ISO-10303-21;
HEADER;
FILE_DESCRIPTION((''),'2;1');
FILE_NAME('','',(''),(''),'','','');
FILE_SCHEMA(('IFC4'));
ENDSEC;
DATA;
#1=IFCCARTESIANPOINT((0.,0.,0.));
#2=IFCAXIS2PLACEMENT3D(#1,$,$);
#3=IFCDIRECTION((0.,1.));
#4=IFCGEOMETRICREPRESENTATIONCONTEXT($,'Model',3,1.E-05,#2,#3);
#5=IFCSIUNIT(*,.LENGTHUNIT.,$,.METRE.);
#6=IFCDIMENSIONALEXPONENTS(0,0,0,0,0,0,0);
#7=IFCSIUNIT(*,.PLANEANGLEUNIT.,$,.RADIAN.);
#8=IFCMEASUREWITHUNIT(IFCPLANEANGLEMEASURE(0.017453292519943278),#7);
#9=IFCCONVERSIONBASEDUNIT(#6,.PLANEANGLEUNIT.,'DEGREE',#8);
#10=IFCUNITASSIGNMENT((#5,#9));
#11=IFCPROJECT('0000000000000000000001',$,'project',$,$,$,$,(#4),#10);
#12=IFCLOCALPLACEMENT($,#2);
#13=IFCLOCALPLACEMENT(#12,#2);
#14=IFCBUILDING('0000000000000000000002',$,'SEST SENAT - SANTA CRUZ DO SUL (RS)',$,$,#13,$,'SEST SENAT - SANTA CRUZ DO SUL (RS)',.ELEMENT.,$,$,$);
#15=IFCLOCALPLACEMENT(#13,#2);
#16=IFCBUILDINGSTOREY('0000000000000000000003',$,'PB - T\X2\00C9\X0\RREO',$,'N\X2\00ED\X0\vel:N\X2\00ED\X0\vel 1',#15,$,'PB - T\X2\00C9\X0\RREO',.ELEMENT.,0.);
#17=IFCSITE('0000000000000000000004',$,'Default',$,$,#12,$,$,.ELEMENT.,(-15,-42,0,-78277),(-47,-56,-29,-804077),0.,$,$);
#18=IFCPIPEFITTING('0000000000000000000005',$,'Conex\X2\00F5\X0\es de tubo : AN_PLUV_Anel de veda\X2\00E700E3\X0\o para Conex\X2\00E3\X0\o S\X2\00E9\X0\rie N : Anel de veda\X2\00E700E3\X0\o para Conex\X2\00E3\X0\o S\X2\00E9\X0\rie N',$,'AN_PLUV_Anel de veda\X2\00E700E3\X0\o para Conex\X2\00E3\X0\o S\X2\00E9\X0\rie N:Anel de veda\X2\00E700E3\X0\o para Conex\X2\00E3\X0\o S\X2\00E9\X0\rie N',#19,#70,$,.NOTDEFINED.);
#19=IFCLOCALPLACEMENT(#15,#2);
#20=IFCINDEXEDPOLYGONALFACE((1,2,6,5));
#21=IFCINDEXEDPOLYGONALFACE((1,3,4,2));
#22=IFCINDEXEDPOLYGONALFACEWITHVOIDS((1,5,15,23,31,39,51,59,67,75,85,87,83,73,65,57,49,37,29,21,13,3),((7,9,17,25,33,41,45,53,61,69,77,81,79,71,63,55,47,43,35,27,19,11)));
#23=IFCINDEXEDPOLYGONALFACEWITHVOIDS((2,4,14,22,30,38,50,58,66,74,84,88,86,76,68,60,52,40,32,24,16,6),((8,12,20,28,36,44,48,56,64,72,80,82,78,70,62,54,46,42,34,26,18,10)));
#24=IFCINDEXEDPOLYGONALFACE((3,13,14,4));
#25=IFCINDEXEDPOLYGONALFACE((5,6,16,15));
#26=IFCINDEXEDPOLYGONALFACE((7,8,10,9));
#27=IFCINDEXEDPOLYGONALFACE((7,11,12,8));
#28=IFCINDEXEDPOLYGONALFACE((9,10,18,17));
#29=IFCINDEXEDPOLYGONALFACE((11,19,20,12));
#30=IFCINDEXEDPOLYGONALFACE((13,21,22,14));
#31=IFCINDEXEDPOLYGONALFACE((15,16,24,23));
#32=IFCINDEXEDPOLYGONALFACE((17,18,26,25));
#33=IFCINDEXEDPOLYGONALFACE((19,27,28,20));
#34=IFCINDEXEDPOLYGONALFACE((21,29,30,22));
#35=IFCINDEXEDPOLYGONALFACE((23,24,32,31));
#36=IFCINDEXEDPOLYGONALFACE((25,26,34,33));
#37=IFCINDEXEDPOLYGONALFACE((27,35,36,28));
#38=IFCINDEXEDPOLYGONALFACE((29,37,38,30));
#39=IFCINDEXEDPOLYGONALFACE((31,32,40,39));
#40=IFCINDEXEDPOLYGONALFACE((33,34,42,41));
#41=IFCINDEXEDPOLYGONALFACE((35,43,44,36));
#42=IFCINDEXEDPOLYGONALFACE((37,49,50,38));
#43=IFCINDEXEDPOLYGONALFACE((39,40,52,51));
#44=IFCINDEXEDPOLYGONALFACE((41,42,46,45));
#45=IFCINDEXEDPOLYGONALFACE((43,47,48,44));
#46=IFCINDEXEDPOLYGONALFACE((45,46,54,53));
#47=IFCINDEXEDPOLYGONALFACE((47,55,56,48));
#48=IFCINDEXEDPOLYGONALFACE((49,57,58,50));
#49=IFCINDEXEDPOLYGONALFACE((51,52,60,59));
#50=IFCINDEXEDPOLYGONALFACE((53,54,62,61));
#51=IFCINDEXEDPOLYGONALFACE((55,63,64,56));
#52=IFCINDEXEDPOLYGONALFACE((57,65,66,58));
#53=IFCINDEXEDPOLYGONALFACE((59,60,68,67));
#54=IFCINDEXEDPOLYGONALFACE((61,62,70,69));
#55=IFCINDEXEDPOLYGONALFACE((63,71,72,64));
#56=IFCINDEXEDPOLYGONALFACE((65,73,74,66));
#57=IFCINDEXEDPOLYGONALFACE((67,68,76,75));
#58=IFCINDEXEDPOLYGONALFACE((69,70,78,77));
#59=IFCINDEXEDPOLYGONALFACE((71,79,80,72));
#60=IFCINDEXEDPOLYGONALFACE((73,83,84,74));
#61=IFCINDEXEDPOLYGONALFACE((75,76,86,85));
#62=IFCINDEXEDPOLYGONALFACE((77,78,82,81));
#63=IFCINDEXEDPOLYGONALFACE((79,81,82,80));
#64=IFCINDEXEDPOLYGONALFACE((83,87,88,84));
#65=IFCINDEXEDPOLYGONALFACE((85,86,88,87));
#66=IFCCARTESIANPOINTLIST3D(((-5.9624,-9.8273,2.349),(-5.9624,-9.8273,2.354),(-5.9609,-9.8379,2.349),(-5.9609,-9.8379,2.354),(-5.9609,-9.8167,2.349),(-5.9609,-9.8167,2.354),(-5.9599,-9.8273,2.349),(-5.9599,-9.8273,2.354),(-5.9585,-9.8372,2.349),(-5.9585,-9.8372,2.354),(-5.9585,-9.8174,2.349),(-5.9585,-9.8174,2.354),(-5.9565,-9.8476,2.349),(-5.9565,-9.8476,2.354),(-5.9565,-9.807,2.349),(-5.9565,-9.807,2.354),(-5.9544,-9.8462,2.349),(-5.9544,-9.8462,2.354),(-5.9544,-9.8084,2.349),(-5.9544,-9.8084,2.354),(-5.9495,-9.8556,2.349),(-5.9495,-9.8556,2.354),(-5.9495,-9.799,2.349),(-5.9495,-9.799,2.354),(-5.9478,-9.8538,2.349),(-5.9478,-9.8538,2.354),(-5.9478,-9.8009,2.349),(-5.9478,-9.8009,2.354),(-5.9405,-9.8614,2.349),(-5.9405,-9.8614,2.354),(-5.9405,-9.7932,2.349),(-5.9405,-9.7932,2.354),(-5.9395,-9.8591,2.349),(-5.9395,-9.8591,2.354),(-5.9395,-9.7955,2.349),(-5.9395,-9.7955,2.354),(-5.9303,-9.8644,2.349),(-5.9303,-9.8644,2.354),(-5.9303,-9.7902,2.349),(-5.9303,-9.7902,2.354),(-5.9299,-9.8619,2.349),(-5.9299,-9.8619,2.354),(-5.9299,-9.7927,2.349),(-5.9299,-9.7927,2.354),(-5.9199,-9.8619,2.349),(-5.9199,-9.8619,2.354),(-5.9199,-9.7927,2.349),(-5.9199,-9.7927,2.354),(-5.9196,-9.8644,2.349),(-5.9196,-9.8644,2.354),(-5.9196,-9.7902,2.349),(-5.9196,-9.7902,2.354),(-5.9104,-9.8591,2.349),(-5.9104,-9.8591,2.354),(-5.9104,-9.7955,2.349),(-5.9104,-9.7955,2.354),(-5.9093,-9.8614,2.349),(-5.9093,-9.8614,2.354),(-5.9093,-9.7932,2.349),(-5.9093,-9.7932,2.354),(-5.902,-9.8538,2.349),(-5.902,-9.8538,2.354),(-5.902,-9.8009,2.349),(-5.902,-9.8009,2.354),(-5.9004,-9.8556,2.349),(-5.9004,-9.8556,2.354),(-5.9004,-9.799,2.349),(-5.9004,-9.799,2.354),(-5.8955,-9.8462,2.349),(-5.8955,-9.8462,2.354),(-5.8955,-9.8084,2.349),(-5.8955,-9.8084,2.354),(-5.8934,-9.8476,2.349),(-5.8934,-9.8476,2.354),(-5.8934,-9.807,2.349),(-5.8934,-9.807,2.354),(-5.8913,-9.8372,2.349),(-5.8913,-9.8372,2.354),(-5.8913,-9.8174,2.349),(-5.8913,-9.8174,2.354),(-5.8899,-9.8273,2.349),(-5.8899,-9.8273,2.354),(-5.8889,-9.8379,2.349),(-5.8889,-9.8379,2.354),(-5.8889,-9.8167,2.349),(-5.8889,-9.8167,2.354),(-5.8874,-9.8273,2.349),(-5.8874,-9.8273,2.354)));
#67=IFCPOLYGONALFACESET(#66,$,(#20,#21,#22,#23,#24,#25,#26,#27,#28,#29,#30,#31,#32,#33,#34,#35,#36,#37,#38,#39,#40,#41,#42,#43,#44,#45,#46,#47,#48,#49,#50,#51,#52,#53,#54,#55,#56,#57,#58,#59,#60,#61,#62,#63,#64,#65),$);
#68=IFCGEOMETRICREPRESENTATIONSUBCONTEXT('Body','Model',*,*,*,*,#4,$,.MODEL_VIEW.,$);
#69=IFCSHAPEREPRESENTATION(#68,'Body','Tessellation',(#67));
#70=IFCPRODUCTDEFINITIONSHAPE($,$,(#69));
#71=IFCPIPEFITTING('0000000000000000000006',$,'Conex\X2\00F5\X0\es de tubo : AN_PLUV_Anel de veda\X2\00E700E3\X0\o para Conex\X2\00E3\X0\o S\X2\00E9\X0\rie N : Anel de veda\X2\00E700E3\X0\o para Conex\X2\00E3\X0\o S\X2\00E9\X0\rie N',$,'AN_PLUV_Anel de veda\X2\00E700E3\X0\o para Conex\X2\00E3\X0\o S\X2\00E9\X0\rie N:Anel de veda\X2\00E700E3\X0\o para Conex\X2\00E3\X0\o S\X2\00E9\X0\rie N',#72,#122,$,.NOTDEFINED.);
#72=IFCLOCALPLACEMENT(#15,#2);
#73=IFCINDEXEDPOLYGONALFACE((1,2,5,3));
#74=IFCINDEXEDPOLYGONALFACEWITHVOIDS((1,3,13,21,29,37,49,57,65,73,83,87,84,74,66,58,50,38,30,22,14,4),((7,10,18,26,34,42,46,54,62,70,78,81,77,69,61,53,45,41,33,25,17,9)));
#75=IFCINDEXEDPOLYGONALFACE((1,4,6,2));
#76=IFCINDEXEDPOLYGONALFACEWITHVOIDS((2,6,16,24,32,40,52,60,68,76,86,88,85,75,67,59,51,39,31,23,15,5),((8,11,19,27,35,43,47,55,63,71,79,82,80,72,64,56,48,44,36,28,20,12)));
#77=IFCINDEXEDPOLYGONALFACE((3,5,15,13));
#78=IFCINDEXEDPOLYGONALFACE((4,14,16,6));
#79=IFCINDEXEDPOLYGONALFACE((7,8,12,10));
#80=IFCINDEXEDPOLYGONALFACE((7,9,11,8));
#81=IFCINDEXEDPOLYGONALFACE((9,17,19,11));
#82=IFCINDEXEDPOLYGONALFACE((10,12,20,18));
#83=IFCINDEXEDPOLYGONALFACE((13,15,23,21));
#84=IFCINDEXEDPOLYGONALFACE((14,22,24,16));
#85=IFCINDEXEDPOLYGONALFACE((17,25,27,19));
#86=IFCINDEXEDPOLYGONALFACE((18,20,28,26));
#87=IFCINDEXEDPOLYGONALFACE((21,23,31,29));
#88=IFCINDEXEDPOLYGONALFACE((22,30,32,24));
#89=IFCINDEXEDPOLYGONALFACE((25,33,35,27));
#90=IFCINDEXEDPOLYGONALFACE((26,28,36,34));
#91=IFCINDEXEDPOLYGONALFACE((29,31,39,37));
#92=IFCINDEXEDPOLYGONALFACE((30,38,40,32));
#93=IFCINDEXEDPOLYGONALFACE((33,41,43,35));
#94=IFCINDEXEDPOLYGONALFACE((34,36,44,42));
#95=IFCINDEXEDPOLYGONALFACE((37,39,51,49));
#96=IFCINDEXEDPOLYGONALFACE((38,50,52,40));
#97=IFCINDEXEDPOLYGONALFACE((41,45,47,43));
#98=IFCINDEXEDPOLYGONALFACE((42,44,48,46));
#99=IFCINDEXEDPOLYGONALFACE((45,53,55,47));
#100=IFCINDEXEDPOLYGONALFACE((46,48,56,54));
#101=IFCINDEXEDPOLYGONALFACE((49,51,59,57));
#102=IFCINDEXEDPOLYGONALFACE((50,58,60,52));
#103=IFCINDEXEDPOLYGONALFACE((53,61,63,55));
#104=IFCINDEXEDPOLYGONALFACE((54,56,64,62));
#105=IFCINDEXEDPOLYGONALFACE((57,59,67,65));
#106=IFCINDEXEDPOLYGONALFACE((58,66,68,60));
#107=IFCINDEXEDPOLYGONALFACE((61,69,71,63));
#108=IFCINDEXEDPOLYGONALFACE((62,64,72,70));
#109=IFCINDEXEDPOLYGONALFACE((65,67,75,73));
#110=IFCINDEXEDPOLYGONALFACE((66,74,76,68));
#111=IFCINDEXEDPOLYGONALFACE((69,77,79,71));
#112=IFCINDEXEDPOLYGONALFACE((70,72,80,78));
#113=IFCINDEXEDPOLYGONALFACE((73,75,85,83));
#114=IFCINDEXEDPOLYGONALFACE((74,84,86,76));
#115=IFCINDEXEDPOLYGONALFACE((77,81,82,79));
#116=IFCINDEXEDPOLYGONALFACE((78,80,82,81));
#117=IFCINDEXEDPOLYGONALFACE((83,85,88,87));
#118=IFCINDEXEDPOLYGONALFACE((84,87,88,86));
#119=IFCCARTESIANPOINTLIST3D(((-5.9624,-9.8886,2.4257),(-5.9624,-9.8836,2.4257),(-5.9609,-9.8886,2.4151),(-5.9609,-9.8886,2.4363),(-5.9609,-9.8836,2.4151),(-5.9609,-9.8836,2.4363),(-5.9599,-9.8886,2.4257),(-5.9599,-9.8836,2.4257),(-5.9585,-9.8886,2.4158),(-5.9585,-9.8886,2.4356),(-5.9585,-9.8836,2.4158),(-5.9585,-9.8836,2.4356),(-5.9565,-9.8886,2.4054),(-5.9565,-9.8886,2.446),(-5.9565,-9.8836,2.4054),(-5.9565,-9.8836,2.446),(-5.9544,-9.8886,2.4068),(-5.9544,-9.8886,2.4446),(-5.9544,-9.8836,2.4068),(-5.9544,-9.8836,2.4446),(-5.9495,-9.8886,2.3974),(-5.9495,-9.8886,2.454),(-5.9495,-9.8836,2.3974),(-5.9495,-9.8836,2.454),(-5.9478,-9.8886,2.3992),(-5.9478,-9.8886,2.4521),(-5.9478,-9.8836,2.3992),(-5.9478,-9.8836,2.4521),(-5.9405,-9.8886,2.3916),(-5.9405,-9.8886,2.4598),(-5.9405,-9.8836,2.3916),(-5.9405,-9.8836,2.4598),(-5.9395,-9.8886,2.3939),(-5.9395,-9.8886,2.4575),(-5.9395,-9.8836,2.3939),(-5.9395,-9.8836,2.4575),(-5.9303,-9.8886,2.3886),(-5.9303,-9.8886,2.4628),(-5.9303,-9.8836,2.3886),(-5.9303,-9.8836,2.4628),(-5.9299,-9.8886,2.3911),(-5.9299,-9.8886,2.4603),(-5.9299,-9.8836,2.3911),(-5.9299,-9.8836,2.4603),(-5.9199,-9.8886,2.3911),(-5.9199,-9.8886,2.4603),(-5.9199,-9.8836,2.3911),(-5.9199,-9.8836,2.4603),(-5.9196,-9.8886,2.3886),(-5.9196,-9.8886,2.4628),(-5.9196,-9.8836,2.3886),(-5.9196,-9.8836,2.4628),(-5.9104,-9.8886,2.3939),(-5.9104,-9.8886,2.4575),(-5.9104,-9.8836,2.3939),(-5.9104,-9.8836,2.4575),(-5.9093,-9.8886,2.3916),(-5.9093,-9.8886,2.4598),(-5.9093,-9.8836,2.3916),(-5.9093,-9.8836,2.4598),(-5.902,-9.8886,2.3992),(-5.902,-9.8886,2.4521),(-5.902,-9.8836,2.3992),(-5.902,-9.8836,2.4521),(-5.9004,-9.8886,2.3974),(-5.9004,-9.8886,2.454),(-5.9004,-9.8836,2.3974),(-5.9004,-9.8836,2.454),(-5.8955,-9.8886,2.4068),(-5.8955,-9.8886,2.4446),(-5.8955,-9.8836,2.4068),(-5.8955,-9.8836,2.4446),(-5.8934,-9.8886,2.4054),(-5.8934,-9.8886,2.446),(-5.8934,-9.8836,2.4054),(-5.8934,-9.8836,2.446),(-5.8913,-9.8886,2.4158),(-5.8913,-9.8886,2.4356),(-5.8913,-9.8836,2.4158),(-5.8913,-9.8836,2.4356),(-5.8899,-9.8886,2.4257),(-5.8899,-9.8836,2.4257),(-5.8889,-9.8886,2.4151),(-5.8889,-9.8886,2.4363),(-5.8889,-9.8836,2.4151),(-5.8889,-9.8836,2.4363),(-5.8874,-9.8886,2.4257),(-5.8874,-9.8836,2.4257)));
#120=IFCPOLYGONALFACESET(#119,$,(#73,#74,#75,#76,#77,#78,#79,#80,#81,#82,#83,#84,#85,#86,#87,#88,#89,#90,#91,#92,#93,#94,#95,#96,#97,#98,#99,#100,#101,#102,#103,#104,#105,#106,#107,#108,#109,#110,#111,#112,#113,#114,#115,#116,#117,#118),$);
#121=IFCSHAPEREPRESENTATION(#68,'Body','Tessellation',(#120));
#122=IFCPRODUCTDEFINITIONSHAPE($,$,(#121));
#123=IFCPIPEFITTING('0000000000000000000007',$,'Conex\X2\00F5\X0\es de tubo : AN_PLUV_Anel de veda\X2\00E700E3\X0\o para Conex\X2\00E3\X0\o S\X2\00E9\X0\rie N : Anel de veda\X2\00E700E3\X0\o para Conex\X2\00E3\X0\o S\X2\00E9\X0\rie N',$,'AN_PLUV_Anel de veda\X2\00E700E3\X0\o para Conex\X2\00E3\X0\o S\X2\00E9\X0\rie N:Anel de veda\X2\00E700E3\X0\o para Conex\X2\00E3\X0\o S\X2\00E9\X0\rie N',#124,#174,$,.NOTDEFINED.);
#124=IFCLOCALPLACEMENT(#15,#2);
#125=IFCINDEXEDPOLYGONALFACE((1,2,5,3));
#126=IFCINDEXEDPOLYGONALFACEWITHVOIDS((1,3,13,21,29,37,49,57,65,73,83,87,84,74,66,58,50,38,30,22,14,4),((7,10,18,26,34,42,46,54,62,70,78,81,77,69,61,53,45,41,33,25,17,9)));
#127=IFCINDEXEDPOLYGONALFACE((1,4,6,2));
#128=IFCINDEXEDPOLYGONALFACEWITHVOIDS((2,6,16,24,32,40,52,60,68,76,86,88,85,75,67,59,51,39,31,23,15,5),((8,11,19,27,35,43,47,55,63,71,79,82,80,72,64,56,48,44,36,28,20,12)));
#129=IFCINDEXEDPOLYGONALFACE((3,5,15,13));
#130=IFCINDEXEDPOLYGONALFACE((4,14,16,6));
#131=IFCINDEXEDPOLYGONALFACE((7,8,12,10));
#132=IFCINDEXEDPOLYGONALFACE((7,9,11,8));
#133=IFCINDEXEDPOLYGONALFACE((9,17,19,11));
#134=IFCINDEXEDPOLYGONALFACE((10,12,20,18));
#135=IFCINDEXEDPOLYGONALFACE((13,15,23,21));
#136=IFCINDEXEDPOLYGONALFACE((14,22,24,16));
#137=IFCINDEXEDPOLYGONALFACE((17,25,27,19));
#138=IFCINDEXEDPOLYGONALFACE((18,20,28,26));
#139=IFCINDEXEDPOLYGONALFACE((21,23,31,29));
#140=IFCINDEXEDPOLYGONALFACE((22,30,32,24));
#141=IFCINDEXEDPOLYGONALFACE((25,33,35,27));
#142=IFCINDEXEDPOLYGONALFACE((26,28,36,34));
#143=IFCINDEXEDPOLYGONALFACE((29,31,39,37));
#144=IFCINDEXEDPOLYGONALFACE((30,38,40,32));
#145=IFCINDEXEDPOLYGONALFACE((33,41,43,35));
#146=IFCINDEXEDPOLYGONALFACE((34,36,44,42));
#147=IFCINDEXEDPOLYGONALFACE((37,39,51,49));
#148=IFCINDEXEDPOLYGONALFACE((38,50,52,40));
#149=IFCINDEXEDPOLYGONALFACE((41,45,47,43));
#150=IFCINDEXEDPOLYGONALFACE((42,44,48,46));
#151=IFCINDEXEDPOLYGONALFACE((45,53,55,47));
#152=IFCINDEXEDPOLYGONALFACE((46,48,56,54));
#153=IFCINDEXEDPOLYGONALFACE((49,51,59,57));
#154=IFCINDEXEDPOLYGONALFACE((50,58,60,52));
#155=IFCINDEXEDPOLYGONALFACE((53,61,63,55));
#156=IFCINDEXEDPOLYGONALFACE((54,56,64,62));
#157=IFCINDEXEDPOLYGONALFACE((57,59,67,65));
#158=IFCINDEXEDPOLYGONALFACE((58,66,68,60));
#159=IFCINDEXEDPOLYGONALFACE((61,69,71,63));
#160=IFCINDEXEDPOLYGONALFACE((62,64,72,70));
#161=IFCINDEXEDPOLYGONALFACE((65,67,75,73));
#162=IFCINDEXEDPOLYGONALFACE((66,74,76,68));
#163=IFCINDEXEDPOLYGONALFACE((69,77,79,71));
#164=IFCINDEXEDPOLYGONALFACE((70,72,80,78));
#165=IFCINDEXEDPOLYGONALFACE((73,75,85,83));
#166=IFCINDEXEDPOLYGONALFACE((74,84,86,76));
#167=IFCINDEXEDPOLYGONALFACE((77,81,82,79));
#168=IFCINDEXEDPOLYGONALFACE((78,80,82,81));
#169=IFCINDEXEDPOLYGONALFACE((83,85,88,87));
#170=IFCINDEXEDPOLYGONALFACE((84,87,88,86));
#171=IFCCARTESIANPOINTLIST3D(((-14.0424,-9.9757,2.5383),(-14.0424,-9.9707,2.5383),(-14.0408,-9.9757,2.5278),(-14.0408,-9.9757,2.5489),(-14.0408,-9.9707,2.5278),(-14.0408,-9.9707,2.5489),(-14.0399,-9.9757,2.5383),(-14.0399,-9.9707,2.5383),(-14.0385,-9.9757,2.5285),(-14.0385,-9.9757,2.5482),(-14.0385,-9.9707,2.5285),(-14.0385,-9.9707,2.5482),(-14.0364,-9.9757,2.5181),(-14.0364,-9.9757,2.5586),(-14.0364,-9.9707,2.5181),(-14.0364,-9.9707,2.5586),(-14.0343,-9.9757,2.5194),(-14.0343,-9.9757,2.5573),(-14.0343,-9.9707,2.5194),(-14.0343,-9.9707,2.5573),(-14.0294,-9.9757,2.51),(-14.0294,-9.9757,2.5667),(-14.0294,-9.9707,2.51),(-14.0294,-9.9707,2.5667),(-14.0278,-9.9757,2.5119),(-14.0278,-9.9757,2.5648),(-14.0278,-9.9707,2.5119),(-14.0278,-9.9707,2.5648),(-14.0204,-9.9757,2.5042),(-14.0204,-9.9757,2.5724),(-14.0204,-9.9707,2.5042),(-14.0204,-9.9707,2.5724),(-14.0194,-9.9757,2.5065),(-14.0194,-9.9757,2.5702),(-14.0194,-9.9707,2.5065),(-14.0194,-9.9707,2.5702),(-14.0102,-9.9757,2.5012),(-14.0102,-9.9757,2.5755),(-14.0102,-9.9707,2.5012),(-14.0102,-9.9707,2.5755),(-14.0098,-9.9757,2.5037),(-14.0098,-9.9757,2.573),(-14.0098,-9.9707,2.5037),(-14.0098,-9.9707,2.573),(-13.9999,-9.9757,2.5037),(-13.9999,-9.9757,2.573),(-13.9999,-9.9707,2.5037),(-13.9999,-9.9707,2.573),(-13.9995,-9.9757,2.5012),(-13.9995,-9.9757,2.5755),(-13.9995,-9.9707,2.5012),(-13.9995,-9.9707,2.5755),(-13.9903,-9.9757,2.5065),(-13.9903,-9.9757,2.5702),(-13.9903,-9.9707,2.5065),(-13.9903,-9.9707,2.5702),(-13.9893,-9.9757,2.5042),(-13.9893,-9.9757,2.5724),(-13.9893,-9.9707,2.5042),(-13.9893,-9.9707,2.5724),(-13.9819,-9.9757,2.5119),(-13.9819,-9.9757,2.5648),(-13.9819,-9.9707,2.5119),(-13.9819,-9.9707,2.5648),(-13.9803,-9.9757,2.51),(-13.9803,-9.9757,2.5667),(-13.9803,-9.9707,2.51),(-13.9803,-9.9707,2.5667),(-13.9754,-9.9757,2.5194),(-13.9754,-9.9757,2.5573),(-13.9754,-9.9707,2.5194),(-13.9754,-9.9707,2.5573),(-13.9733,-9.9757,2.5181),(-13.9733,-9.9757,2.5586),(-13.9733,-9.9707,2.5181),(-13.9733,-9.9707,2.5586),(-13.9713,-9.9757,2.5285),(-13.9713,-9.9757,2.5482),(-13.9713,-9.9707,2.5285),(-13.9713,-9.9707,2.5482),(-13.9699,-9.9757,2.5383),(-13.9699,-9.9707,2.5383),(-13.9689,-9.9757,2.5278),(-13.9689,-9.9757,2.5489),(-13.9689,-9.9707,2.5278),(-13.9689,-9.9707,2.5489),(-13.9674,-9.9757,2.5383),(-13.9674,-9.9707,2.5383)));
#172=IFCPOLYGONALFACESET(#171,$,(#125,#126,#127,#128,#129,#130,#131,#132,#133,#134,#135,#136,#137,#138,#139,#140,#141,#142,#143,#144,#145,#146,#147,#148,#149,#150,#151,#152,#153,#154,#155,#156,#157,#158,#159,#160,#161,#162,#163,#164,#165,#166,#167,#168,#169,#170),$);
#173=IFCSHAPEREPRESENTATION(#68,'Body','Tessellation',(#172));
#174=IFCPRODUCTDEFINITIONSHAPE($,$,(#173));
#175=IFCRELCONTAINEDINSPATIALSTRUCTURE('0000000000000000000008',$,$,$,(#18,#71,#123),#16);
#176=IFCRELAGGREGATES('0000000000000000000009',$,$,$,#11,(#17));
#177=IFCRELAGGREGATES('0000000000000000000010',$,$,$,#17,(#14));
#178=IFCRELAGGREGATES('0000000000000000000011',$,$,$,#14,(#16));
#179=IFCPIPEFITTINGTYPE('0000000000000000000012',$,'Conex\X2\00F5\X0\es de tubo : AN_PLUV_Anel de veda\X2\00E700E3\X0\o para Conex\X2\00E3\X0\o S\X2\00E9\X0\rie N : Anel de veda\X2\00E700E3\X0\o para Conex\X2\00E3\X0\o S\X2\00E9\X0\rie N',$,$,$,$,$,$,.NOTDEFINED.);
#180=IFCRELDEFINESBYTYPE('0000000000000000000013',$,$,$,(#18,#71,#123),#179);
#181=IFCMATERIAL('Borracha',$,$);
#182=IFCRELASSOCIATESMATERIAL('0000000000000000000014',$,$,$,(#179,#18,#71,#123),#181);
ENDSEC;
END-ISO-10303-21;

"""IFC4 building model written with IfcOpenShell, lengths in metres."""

from ifc_helpers import new_model, entity, si_unit, converted_unit, direction, frame, origin, place, context, subcontext, project, spatial, arc, indexed_curve, outline, extrude, source, transform, mapped, material, type_object, type_shapes, element, save


model = new_model("IFC4")

# Units and contexts
model_context = context("Model", 3, precision=1e-05, world=origin(), true_north=direction((0.0, 1.0)))
body_context = subcontext(model_context, "Body", "Model", "MODEL_VIEW")
ifc_project = project(units=[si_unit("LENGTHUNIT", "METRE"), converted_unit("PLANEANGLEUNIT", "DEGREE", entity("IfcPlaneAngleMeasure", 0.017453292519943278), si_unit("PLANEANGLEUNIT", "RADIAN"), dimensions=[0, 0, 0, 0, 0, 0, 0])], contexts=[model_context])

# Site, building, storey
site_placement = place(None, origin())
site = spatial("IfcSite", under=ifc_project, at=site_placement, Name="Default", CompositionType="ELEMENT", RefLatitude=(-15, -42, 0, -78277), RefLongitude=(-47, -56, -29, -804077), RefElevation=0.0)
building_placement = place(site_placement, origin())
building = spatial("IfcBuilding", under=site, at=building_placement, Name="SEST SENAT - SANTA CRUZ DO SUL (RS)", LongName="SEST SENAT - SANTA CRUZ DO SUL (RS)", CompositionType="ELEMENT")
storey_placement = place(building_placement, origin())
storey = spatial("IfcBuildingStorey", under=building, at=storey_placement, Name="PB - TÉRREO", ObjectType="Nível:Nível 1", LongName="PB - TÉRREO", CompositionType="ELEMENT", Elevation=0.0)

# Pipe fittings
ifc_material = material(Name="Borracha")
pipe_fitting_type = type_object("IfcPipeFittingType", Name="Conexões de tubo : AN_PLUV_Anel de vedação para Conexão Série N : Anel de vedação para Conexão Série N", PredefinedType="NOTDEFINED", material=ifc_material)
shared_shape = source(origin(), body_context, "Body", "SweptSolid", [
    extrude(outline(indexed_curve([(-0.0375, 0.0), (0.0, -0.0375), (0.0375, 0.0), (0.0, 0.0375)], segments=[arc(1, 2, 3), arc(3, 4, 1)], self_intersect=False), holes=[indexed_curve([(-0.035, 0.0), (0.0, 0.035), (0.035, 0.0), (0.0, -0.035)], segments=[arc(1, 2, 3), arc(3, 4, 1)], self_intersect=False)]), frame((0.0, 0.0, -0.005)), (0.0, 0.0, 1.0), 0.005),
])
type_shapes(pipe_fitting_type, [shared_shape])
for number, where, z_axis, x_axis, name in (
    (1, (-5.9249, -9.8273, 2.349), (0.0, 0.0, -1.0), (1.0, 0.0, 0.0), "Conexões de tubo : AN_PLUV_Anel de vedação para Conexão Série N : Anel de vedação para Conexão Série N"),
    (2, (-5.9249, -9.8836, 2.4257), (0.0, 1.0, 0.0), (1.0, 0.0, 0.0), "Conexões de tubo : AN_PLUV_Anel de vedação para Conexão Série N : Anel de vedação para Conexão Série N"),
    (3, (-14.0049, -9.9707, 2.5383), (0.0, 1.0, 0.0), (-1.0, 0.0, 0.0), "Conexões de tubo : AN_PLUV_Anel de vedação para Conexão Série N : Anel de vedação para Conexão Série N"),
):
    element("IfcPipeFitting", number, at=place(storey_placement, frame(where, z_axis=z_axis, x_axis=x_axis)), inside=storey, type_object=pipe_fitting_type, material=ifc_material, Name=name, ObjectType="AN_PLUV_Anel de vedação para Conexão Série N:Anel de vedação para Conexão Série N", PredefinedType="NOTDEFINED", context=body_context, shape_type="MappedRepresentation", body=[
        mapped(shared_shape, transform((0.0, 0.0, 0.0), scale=1.0)),
    ])

save(model, "model.ifc")
